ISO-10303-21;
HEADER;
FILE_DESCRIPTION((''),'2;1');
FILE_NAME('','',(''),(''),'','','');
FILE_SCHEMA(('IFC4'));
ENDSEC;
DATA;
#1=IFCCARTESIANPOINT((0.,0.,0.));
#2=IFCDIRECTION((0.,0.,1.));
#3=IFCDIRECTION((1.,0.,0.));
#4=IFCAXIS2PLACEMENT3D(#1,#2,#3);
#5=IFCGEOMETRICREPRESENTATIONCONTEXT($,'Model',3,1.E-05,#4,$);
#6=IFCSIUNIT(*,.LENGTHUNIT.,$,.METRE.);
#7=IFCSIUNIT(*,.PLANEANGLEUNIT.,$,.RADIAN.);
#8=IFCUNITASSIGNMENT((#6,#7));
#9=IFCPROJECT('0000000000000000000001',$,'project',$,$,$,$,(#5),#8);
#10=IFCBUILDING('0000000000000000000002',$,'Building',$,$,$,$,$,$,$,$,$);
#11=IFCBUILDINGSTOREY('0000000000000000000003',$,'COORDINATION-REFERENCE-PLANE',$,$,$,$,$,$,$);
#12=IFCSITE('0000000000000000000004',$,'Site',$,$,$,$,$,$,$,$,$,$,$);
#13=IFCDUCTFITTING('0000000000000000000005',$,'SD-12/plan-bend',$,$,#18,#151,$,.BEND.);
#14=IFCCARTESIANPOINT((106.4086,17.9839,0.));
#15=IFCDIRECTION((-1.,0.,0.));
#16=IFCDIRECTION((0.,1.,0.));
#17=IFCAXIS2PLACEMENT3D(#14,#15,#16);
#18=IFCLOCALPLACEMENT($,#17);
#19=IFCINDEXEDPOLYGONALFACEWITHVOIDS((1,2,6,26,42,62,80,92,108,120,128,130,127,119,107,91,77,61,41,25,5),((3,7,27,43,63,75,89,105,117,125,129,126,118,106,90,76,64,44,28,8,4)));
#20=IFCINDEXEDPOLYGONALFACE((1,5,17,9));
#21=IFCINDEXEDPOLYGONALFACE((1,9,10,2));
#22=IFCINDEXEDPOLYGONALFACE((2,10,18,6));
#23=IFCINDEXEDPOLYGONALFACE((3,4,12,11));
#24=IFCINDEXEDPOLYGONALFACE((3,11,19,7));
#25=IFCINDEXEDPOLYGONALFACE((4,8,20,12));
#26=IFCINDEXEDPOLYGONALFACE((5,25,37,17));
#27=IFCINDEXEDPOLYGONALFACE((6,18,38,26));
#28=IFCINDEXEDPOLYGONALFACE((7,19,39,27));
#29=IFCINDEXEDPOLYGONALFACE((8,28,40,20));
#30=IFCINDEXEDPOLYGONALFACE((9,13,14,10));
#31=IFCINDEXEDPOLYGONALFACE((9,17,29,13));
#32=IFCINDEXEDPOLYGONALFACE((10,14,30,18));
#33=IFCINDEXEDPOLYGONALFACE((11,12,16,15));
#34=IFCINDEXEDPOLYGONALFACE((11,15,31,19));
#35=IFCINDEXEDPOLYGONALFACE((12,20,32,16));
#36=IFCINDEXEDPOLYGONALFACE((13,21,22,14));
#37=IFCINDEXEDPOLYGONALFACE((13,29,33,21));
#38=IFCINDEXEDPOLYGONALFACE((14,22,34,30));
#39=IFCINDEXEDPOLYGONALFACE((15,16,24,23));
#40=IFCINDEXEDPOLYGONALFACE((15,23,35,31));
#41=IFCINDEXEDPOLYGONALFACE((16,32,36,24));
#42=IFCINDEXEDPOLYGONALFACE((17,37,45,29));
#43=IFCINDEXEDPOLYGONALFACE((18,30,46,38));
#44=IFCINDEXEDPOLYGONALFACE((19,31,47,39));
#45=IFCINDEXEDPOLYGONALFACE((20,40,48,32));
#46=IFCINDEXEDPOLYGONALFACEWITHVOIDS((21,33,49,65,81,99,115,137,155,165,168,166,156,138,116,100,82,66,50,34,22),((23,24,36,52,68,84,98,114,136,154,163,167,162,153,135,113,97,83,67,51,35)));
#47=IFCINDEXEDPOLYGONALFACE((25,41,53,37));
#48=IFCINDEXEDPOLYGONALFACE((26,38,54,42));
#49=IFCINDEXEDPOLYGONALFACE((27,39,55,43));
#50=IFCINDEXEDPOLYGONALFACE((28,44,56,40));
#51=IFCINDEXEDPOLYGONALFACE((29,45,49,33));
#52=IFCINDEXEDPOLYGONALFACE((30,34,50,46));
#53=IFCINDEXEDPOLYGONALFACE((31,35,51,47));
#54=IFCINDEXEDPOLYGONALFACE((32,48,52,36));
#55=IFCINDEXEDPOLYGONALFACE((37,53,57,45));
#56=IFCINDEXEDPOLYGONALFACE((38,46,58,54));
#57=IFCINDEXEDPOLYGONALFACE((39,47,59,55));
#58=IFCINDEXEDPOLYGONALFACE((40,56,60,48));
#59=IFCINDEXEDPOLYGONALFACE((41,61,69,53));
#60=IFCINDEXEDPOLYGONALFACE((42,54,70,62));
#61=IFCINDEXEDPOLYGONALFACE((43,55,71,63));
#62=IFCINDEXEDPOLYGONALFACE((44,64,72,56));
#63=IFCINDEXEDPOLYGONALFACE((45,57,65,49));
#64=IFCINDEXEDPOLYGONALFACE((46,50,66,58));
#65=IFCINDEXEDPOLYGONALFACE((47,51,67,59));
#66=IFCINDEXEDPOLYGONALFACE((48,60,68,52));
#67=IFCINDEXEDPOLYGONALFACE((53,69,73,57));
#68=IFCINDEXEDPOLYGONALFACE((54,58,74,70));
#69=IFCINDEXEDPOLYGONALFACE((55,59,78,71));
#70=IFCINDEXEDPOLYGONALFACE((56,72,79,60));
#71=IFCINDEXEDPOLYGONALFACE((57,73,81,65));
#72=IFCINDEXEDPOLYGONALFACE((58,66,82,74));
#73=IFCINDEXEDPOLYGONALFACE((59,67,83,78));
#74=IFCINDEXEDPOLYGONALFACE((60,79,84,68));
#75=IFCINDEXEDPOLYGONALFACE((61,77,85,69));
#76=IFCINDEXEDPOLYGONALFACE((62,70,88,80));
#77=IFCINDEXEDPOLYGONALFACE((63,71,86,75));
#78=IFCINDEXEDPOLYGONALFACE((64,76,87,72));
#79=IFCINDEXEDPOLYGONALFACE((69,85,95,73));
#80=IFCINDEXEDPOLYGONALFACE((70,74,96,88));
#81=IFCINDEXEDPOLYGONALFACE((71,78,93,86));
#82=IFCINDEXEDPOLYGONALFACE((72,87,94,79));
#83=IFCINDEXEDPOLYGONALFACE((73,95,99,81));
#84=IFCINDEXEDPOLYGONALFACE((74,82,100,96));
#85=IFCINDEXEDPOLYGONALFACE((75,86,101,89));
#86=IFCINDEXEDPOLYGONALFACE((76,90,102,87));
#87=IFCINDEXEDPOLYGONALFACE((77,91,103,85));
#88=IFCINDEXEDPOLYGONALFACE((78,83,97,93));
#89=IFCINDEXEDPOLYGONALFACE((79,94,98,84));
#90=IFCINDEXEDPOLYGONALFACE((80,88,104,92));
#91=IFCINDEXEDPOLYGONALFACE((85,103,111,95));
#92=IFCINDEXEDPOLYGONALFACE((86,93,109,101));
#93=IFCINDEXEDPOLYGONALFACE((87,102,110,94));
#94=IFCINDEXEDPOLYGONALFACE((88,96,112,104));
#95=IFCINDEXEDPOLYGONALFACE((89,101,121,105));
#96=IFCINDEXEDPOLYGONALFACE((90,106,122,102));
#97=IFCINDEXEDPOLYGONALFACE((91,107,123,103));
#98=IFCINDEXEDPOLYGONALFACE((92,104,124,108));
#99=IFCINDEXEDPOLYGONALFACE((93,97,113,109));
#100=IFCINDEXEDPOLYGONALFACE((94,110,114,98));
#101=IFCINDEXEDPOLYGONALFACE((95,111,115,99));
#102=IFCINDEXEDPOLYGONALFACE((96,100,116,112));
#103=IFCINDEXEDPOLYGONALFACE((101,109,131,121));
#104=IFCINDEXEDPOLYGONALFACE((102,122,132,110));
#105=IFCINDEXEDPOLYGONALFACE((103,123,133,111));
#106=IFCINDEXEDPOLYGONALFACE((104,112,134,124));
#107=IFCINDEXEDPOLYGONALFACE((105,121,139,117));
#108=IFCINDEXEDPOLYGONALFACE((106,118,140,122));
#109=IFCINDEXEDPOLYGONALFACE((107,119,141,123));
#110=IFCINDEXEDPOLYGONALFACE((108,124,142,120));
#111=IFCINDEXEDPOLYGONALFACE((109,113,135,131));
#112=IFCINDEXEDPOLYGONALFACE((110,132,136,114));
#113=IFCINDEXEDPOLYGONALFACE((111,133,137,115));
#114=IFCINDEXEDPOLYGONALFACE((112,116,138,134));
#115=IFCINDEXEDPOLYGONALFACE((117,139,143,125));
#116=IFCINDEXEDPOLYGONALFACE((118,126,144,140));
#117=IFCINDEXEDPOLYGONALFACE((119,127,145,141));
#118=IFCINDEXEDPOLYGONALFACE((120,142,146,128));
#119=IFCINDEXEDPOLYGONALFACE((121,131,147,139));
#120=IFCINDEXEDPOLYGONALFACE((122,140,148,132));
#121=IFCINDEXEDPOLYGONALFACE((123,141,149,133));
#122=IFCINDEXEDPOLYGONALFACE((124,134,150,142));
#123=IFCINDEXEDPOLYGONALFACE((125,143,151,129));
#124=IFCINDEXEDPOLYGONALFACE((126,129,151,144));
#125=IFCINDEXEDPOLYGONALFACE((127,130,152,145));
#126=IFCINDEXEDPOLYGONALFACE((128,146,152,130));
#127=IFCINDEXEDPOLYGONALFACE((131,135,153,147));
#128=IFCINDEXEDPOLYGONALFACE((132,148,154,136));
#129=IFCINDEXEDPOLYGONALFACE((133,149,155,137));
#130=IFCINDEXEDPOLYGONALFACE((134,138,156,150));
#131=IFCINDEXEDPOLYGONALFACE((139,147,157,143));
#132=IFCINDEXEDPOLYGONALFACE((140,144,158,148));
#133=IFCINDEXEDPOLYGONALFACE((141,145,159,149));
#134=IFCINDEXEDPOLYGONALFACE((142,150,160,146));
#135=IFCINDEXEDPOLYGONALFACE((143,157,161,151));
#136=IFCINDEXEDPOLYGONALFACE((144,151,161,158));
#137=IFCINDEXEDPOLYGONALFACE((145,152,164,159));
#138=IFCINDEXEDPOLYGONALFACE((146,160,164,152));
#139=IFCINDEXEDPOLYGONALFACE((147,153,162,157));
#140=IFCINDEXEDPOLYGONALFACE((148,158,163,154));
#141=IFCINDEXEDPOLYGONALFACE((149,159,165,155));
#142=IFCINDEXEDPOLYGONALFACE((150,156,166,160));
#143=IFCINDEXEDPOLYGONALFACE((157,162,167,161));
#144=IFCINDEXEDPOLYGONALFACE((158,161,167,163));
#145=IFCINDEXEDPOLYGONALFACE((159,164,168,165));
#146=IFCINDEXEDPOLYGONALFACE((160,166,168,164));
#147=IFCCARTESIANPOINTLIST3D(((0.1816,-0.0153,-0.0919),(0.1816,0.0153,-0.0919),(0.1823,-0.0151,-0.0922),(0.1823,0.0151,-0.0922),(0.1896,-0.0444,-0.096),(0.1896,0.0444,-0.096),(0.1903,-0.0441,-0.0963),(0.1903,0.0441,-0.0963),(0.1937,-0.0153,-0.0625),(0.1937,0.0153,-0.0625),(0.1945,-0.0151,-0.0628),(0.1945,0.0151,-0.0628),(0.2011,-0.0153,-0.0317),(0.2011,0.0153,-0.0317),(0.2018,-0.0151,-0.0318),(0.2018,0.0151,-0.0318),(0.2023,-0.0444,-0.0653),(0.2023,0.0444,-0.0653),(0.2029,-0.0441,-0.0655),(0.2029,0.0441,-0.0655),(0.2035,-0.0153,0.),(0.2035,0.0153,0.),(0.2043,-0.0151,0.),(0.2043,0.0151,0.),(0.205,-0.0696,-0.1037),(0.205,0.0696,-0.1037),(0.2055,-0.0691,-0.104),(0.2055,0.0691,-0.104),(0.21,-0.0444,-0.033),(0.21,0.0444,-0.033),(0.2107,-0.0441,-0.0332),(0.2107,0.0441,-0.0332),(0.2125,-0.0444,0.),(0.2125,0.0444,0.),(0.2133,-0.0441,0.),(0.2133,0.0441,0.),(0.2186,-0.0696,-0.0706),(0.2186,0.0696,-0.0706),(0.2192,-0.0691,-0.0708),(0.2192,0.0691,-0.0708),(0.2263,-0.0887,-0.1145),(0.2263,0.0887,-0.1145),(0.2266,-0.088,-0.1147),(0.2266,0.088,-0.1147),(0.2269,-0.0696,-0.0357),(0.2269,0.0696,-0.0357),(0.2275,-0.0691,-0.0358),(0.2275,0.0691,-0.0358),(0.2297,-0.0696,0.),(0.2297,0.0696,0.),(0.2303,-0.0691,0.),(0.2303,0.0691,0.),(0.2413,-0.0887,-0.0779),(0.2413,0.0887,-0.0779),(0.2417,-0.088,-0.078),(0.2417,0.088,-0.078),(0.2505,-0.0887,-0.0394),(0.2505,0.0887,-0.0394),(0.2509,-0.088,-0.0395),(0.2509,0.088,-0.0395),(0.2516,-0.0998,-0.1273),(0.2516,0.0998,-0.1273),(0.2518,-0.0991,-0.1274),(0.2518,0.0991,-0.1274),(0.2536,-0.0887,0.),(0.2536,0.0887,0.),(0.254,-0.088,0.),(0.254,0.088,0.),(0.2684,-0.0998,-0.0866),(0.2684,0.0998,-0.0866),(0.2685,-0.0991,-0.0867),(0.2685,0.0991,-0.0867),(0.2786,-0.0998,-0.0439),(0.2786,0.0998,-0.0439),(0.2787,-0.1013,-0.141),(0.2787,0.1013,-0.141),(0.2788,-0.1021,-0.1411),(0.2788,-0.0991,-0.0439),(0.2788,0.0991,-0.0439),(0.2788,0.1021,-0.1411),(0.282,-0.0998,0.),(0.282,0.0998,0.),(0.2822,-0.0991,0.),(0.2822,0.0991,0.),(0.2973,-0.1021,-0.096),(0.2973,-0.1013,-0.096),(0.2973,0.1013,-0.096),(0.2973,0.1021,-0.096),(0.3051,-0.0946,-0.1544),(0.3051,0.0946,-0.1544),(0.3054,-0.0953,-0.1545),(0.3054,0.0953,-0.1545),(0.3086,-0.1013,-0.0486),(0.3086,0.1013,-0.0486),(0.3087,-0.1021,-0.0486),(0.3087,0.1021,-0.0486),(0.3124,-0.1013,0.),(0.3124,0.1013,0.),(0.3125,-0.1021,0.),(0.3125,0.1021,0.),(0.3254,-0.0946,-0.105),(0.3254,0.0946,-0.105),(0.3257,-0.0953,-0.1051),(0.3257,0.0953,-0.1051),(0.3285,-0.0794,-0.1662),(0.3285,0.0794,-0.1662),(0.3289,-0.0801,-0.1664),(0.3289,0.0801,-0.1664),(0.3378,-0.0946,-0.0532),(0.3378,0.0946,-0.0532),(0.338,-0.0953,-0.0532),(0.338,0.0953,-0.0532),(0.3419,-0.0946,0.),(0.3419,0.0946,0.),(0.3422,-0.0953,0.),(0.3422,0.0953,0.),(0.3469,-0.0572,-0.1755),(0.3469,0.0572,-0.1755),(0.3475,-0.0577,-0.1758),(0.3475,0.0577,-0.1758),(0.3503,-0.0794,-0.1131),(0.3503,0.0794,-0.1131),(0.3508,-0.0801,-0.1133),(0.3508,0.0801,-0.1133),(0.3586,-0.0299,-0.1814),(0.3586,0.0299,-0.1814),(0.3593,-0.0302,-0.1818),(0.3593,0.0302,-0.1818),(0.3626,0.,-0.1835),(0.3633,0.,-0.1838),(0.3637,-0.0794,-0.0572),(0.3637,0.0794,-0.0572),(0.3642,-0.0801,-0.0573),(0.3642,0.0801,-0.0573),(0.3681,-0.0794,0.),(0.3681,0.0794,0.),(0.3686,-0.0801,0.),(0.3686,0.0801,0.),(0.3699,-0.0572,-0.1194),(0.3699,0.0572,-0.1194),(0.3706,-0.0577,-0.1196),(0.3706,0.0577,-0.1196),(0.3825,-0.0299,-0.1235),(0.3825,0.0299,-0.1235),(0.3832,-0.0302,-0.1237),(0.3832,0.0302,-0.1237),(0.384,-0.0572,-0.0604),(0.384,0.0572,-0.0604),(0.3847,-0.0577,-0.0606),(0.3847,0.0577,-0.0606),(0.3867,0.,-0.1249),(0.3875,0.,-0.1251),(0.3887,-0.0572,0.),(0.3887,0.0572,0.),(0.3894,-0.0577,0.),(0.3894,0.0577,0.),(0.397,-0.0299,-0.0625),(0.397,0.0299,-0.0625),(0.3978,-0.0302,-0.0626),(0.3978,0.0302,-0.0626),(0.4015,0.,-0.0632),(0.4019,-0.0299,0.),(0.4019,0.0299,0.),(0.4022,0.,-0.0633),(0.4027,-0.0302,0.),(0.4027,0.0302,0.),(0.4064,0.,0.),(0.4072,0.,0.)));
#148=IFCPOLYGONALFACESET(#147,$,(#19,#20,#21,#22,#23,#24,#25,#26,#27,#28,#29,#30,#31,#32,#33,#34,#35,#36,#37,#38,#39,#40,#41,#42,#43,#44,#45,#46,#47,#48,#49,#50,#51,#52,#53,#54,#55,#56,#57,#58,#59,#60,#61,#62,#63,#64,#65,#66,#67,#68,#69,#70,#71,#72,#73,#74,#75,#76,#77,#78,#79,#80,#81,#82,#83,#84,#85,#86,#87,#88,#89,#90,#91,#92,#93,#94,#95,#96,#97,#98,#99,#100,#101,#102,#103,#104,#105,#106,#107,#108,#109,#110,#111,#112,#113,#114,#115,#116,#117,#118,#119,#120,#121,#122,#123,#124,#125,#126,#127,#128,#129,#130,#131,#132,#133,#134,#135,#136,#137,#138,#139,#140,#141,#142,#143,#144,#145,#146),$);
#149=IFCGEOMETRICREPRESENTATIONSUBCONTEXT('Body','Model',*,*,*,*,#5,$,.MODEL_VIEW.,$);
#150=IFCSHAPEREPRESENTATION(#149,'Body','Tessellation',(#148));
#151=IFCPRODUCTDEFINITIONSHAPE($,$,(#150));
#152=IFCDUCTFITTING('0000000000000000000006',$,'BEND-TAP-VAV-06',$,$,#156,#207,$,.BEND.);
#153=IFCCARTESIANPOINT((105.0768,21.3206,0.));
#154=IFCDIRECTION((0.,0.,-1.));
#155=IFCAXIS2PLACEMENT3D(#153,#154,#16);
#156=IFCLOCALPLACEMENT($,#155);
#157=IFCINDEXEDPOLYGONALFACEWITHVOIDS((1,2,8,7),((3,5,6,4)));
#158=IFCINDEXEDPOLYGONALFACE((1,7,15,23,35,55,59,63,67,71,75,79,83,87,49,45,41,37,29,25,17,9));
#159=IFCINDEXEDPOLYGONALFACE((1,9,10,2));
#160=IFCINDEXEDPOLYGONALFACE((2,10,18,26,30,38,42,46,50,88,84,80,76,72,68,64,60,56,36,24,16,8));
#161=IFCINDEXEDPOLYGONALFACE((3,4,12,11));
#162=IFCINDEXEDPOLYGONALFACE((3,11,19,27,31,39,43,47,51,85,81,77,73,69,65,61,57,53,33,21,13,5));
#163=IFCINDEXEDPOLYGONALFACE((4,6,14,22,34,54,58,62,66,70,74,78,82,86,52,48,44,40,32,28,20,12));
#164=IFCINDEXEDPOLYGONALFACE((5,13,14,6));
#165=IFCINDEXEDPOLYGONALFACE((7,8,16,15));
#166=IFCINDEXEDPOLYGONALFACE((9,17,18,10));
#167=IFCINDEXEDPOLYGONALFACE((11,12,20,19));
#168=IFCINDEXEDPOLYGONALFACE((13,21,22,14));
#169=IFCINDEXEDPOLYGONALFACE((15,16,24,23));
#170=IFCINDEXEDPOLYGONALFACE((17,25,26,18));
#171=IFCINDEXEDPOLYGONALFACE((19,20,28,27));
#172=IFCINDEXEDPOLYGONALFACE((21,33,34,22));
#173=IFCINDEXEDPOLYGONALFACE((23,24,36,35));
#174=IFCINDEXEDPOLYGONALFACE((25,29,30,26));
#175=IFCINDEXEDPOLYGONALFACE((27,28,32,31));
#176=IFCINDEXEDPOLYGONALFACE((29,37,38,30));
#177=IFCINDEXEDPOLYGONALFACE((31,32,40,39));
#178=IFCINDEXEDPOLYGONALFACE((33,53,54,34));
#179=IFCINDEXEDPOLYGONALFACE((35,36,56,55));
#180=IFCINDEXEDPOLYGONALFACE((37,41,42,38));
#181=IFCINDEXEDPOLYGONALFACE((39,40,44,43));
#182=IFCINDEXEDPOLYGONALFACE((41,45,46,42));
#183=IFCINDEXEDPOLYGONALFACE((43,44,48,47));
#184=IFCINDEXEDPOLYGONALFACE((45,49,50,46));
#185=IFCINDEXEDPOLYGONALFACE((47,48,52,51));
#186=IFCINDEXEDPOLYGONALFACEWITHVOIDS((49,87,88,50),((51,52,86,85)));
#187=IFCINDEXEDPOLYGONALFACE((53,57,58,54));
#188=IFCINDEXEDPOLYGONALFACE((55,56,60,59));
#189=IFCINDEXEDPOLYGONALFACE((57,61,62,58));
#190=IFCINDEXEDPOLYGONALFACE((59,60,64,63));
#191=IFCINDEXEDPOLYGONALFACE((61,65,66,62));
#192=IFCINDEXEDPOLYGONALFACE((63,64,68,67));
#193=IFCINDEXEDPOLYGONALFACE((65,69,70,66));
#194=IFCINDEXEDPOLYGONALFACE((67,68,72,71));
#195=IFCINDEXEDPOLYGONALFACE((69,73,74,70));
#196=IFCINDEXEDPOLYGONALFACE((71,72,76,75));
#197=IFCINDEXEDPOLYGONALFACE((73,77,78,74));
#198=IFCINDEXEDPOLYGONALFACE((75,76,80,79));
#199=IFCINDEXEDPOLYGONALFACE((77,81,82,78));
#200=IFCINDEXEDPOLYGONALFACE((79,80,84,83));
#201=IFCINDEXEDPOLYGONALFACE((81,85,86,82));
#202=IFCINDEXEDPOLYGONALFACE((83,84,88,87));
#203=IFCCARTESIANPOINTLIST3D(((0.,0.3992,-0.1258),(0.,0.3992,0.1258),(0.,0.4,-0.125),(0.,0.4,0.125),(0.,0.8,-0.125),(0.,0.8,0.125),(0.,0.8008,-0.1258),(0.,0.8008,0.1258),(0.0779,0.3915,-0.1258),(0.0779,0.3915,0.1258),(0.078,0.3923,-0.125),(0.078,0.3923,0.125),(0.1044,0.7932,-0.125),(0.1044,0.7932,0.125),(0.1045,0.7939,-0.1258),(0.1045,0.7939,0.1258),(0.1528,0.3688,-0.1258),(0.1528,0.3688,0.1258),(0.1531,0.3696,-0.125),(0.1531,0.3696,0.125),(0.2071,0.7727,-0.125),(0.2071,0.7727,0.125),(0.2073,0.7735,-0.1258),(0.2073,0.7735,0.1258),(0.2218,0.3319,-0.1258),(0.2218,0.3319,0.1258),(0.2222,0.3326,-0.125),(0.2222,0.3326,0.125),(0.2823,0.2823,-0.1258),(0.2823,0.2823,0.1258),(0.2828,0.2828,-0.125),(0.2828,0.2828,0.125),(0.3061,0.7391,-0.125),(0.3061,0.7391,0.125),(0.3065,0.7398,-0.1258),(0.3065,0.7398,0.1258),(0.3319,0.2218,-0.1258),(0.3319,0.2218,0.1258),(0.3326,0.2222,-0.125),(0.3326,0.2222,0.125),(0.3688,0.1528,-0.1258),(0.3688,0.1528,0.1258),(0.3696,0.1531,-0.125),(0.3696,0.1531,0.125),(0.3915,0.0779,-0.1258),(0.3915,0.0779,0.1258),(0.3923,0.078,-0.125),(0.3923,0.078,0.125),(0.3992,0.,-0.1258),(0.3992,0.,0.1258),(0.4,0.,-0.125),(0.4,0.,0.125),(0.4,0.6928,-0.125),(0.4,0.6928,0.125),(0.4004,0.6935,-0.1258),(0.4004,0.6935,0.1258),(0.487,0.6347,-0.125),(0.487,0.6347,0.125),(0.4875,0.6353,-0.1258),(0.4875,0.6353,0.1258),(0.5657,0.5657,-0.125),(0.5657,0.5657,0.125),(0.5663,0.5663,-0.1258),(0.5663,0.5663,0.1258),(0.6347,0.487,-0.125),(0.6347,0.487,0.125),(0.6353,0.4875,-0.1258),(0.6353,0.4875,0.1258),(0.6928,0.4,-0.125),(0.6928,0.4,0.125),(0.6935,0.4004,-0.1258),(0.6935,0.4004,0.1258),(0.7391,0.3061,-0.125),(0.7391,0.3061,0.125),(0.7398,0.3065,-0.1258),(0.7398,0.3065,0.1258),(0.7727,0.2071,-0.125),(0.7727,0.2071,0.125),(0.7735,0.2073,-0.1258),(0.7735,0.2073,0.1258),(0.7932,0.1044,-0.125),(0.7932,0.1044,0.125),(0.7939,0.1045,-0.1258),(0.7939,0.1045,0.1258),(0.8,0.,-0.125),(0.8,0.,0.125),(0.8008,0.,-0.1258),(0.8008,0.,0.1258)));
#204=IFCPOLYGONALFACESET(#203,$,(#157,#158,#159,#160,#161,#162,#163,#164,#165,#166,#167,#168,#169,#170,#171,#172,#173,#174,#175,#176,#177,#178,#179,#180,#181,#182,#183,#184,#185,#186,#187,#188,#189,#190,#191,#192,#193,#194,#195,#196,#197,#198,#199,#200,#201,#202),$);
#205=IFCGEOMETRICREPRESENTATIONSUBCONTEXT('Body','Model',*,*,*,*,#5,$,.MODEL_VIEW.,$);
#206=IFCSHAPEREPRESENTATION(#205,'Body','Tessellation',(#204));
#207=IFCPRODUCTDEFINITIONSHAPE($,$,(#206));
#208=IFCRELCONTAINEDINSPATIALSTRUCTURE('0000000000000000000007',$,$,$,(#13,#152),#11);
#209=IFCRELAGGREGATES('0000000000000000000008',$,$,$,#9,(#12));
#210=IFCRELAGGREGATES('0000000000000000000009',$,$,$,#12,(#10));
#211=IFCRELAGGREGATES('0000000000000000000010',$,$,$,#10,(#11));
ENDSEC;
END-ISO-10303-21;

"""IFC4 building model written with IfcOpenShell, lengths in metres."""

from ifc_helpers import new_model, entity, si_unit, frame, origin_with_axes, place, context, subcontext, project, spatial, element, save


model = new_model("IFC4")

# Units and contexts
model_context = context("Model", 3, precision=1e-05, world=origin_with_axes())
body_context_1 = subcontext(model_context, "Body", "Model", "MODEL_VIEW")
body_context_2 = subcontext(model_context, "Body", "Model", "MODEL_VIEW")
ifc_project = project(units=[si_unit("LENGTHUNIT", "METRE"), si_unit("PLANEANGLEUNIT", "RADIAN")], contexts=[model_context])

# Site, building, storey
site = spatial("IfcSite", under=ifc_project, Name="Site")
building = spatial("IfcBuilding", under=site, Name="Building")
storey = spatial("IfcBuildingStorey", under=building, Name="COORDINATION-REFERENCE-PLANE")

# Duct fitting
duct_fitting_1_placement = place(None, frame((106.4086, 17.9839, 0.0), z_axis=(-1.0, 0.0, 0.0), x_axis=(0.0, 1.0, 0.0)))
element("IfcDuctFitting", 1, at=duct_fitting_1_placement, inside=storey, Name="SD-12/plan-bend", PredefinedType="BEND", context=body_context_1, shape_type="SweptSolid", body=[
    entity("IfcRevolvedAreaSolid", entity("IfcCircleHollowProfileDef", "AREA", None, entity("IfcAxis2Placement2D", entity("IfcCartesianPoint", [0.3048, 0.0])), 0.1024, 0.0008), entity("IfcAxis2Placement3D", entity("IfcCartesianPoint", [0.0, 0.0, 0.0]), entity("IfcDirection", [0.0, 0.0, 1.0]), entity("IfcDirection", [1.0, 0.0, 0.0])), entity("IfcAxis1Placement", entity("IfcCartesianPoint", [0.0, 0.0, 0.0]), entity("IfcDirection", [0.0, 1.0, 0.0])), 0.468399),
])

# Duct fitting
duct_fitting_2_placement = place(None, frame((105.0768, 21.3206, 0.0), z_axis=(0.0, 0.0, -1.0), x_axis=(0.0, 1.0, 0.0)))
cartesian_point = entity("IfcCartesianPoint", [0.0, 0.0, 0.0])
element("IfcDuctFitting", 2, at=duct_fitting_2_placement, inside=storey, Name="BEND-TAP-VAV-06", PredefinedType="BEND", context=body_context_2, shape_type="SweptSolid", body=[
    entity("IfcRevolvedAreaSolid", entity("IfcRectangleHollowProfileDef", "AREA", None, entity("IfcAxis2Placement2D", entity("IfcCartesianPoint", [0.6, 0.0])), 0.4016, 0.2516, 0.0008), entity("IfcAxis2Placement3D", cartesian_point, entity("IfcDirection", [0.0, -1.0, 0.0]), entity("IfcDirection", [1.0, 0.0, 0.0])), entity("IfcAxis1Placement", cartesian_point, entity("IfcDirection", [0.0, 1.0, 0.0])), 1.570796),
])

save(model, "model.ifc")
